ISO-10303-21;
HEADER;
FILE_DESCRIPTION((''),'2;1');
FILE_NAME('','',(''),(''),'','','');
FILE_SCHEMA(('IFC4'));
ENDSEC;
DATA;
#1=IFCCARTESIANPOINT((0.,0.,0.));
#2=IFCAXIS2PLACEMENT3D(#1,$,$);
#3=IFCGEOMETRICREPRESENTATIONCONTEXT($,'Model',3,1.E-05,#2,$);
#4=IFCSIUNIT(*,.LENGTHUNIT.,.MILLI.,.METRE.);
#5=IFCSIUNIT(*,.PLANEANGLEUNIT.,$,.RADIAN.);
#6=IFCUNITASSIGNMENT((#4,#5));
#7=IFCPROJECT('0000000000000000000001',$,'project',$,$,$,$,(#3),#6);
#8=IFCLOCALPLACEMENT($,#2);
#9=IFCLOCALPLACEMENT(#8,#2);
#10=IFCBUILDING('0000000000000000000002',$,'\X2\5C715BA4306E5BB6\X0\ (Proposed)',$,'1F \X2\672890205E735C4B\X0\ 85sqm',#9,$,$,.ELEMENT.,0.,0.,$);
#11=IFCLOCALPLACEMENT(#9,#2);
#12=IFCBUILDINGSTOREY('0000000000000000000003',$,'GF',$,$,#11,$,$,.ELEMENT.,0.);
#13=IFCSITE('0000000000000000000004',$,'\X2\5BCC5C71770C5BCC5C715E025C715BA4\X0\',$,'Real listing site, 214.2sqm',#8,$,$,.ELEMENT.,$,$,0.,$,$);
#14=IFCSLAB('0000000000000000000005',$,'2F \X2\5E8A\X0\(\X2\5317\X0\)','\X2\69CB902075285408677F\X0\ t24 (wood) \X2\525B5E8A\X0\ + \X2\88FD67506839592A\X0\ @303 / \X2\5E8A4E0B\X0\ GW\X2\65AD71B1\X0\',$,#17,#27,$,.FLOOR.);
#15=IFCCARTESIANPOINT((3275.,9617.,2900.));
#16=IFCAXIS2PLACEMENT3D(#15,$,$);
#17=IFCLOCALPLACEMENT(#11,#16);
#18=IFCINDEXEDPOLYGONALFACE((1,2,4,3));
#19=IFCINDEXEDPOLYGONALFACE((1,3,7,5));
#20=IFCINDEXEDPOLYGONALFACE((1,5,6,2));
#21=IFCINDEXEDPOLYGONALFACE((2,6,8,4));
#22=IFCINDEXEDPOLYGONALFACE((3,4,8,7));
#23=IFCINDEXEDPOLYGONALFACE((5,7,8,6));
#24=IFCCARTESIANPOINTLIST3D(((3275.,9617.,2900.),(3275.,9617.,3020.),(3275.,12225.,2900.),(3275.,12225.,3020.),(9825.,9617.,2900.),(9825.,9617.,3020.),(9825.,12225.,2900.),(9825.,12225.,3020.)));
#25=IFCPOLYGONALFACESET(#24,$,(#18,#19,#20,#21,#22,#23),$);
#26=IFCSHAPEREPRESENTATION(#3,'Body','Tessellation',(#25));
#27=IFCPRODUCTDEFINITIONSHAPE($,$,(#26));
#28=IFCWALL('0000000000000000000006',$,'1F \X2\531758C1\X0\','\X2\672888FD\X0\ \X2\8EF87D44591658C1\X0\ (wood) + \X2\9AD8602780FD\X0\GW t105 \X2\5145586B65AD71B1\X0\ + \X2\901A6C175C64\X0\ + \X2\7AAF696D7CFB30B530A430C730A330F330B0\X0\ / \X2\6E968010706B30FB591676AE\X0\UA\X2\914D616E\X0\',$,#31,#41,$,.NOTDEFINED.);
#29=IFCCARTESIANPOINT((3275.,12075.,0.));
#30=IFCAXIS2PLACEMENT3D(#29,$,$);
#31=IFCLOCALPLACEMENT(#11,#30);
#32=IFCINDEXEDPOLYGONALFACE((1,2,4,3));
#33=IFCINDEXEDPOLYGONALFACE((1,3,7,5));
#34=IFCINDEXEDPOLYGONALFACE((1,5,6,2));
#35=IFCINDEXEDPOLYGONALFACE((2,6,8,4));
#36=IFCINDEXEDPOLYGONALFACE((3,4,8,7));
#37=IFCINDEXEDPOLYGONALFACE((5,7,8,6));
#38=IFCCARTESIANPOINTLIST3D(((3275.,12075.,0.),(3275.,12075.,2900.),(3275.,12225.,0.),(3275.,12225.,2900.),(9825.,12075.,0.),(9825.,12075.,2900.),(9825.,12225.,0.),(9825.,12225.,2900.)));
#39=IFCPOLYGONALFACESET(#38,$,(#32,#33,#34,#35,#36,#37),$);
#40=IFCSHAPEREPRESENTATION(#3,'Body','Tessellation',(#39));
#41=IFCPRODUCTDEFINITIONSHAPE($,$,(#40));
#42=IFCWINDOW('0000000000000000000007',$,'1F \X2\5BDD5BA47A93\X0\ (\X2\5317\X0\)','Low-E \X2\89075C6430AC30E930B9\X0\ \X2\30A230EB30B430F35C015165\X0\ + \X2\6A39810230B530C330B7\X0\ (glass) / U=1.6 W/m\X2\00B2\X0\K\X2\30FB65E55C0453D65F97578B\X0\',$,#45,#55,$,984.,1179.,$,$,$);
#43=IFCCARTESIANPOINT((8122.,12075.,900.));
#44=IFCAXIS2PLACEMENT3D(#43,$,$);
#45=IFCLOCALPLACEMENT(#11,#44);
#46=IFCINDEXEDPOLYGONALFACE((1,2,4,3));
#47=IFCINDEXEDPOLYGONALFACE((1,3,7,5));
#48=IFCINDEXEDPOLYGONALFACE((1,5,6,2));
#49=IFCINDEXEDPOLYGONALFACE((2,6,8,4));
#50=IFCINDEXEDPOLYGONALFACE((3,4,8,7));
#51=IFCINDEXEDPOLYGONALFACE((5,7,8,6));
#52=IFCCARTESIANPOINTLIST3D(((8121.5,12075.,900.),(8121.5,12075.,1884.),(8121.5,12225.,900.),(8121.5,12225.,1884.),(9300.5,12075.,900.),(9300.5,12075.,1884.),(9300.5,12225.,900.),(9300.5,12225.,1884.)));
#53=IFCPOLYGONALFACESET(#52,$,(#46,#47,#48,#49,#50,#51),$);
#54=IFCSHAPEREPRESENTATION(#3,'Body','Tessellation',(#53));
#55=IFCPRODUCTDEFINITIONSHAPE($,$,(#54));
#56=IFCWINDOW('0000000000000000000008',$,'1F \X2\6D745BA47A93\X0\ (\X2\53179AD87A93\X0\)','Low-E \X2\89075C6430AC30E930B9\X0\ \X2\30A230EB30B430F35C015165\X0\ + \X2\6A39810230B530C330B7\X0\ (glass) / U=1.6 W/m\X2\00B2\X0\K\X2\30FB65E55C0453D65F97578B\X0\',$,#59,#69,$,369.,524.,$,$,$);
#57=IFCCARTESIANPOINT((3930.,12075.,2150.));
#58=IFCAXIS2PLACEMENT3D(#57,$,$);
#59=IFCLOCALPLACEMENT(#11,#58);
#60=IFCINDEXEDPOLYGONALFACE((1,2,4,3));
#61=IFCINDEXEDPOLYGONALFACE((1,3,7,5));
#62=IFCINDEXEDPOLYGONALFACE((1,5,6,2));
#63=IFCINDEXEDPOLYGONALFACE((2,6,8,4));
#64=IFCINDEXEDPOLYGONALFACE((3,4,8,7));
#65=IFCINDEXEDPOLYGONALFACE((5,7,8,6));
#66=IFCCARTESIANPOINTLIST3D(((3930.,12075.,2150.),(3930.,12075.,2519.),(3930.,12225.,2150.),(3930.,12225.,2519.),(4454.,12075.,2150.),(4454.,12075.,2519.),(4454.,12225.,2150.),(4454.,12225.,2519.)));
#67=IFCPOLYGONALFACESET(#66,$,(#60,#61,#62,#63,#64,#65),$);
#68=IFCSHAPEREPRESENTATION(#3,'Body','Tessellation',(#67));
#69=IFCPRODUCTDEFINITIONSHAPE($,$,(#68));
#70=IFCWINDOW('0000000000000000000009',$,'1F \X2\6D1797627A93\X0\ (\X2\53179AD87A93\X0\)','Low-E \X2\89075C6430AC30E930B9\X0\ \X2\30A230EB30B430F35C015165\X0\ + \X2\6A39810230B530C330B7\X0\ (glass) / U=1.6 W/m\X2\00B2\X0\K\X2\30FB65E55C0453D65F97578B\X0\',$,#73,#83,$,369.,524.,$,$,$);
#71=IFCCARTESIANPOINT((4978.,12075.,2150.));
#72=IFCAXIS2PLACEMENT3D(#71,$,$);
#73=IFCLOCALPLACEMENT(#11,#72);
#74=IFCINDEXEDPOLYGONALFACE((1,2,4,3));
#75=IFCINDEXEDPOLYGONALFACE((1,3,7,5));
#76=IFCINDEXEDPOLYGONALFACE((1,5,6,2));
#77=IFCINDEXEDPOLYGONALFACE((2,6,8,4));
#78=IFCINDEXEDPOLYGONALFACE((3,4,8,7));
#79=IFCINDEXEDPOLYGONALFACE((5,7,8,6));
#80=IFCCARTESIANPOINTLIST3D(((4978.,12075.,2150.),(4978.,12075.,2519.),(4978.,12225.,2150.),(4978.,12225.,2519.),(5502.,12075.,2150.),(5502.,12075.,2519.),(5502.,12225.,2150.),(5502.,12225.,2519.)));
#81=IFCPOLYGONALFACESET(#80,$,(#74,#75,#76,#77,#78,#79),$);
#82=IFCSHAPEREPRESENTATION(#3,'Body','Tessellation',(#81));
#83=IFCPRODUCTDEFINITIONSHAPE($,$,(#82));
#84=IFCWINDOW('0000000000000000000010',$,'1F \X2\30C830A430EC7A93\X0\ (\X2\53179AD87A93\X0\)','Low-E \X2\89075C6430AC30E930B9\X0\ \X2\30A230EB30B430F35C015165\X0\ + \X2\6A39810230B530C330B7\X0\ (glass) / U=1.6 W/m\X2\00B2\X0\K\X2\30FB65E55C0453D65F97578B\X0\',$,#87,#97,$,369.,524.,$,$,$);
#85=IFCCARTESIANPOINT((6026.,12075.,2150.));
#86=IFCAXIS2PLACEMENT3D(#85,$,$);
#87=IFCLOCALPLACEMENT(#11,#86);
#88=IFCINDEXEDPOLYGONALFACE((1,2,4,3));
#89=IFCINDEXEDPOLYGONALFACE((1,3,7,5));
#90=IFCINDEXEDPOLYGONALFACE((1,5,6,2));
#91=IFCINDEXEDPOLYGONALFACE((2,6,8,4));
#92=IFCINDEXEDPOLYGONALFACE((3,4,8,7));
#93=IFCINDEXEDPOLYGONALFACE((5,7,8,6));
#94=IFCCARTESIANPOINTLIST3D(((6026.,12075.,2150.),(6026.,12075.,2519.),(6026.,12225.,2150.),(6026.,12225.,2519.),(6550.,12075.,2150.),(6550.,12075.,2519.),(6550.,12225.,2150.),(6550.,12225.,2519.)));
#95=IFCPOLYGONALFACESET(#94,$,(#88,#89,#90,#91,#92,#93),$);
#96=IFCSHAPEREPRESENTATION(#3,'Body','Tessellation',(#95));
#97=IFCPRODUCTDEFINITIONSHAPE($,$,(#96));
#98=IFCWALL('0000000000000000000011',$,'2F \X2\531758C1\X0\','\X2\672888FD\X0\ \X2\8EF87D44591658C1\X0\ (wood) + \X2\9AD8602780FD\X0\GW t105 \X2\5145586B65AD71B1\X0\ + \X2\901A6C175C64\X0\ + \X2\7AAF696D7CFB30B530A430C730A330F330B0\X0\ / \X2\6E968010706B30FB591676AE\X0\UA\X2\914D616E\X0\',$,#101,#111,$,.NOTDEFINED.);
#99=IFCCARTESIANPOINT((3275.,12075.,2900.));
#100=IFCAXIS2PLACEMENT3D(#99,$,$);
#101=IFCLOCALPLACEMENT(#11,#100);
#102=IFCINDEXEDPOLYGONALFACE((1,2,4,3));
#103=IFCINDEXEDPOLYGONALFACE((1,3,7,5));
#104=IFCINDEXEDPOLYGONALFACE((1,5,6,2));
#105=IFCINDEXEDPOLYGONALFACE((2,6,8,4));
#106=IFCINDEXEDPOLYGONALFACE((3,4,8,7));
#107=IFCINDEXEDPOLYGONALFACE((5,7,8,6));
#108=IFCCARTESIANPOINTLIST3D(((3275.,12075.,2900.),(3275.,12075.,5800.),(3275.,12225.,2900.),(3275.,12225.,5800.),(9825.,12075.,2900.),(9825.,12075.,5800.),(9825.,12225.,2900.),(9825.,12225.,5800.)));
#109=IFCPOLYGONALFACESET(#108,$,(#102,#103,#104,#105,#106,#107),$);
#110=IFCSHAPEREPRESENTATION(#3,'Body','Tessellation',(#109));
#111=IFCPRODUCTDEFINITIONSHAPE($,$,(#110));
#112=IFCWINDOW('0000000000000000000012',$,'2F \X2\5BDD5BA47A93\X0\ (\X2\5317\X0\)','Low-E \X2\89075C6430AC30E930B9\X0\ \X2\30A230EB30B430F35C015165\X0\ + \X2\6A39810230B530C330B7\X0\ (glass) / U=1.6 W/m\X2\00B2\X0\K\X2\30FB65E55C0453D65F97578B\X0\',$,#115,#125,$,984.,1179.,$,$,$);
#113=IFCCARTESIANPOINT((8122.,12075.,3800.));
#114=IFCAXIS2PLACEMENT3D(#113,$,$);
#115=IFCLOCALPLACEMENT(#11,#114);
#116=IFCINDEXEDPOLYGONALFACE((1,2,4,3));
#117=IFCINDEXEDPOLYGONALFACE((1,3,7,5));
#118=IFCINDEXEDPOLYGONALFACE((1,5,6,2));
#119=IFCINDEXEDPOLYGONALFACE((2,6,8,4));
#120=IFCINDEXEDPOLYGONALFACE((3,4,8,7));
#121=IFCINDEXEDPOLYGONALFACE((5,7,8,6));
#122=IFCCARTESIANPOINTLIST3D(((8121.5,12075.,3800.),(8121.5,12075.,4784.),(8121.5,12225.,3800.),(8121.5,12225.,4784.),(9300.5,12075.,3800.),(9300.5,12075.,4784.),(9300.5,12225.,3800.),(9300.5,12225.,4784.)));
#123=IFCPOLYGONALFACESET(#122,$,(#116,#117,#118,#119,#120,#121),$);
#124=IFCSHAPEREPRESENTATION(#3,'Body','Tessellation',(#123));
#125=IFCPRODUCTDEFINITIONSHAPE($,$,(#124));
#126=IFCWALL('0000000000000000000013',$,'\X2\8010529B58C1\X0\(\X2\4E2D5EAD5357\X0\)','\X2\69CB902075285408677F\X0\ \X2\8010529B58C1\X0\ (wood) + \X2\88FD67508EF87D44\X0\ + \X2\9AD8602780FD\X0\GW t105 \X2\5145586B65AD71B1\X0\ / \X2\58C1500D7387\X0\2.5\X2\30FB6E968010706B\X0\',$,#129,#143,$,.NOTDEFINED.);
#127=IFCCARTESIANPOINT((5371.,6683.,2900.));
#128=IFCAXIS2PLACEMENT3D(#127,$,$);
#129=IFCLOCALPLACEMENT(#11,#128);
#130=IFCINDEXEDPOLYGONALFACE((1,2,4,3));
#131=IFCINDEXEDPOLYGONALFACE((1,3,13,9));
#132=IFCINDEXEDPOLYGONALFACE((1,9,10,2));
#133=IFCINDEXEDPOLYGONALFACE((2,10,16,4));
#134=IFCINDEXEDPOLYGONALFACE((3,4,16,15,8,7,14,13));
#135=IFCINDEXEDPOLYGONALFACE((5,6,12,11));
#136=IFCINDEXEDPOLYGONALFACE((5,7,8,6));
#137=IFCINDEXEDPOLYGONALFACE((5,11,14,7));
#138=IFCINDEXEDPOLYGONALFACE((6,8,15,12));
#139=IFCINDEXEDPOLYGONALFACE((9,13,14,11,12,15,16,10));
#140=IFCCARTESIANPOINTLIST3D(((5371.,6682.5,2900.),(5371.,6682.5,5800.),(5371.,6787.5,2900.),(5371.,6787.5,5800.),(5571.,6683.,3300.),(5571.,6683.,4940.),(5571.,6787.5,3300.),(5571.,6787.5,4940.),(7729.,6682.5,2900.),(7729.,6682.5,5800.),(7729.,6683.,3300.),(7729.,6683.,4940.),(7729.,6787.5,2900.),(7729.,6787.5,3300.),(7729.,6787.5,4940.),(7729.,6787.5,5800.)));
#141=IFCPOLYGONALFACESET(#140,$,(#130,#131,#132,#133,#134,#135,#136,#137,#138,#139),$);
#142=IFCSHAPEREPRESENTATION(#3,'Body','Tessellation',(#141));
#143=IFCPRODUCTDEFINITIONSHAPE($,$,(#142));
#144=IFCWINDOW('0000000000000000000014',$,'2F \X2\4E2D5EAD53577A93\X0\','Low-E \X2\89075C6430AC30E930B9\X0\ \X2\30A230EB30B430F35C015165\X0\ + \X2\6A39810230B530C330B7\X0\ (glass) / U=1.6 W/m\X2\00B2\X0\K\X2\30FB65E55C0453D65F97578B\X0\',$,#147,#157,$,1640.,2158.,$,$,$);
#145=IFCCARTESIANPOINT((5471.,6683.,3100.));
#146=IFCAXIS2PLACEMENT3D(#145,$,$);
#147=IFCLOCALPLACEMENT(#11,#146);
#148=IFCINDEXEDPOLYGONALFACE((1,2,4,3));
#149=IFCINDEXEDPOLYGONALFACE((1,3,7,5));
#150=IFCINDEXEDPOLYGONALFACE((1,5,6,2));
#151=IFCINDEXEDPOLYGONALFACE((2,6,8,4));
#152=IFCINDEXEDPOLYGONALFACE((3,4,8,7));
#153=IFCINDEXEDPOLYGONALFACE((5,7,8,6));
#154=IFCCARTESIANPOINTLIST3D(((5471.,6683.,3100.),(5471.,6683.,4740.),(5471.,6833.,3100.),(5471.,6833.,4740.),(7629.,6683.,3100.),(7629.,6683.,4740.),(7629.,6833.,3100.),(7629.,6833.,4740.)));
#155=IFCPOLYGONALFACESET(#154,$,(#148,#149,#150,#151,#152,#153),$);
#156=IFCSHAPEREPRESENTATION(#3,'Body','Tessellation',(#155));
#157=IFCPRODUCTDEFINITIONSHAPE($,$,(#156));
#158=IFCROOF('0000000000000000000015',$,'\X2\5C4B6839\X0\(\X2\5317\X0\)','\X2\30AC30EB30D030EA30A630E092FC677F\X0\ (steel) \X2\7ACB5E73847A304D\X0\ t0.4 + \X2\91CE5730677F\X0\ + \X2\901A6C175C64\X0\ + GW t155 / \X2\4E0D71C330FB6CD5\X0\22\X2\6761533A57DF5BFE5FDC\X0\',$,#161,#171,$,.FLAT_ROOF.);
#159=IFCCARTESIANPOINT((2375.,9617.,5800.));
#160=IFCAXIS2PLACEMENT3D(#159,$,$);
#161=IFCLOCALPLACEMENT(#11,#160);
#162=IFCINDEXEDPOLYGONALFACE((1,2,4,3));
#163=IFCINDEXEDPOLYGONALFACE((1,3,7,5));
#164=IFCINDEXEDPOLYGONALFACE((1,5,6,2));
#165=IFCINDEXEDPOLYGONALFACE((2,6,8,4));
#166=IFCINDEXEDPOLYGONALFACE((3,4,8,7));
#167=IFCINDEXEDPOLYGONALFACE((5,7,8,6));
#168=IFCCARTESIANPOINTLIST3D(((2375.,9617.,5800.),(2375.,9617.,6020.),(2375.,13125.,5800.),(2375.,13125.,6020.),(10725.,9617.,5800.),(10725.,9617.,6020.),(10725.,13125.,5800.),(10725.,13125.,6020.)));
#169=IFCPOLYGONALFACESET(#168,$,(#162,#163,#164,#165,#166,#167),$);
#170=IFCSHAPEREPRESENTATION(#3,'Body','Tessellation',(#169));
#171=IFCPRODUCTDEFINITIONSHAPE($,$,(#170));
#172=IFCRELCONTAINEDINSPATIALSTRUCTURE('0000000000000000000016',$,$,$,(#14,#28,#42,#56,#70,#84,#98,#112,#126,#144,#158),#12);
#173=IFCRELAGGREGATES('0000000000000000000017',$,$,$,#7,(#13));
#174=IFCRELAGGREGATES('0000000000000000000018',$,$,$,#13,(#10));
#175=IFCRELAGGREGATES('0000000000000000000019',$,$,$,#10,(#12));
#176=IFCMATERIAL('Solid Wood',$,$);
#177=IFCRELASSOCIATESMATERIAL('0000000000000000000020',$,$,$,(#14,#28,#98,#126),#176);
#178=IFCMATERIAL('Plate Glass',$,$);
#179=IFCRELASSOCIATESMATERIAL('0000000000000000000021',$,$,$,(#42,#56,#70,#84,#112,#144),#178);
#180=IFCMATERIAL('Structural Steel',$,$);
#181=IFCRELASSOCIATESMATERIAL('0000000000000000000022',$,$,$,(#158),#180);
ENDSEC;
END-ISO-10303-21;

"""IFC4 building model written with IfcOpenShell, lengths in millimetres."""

from ifc_helpers import new_model, si_unit, frame, frame_2d, origin, place, context, project, spatial, rectangle, extrude, material, element, fill, save


model = new_model("IFC4")

# Units and contexts
model_context = context("Model", 3, precision=1e-05, world=origin())
ifc_project = project(units=[si_unit("LENGTHUNIT", "METRE", prefix="MILLI"), si_unit("PLANEANGLEUNIT", "RADIAN")], contexts=[model_context])

# Site, building, storey
site_placement = place(None, origin())
site = spatial("IfcSite", under=ifc_project, at=site_placement, Name="富山県富山市山室", ObjectType="Real listing site, 214.2sqm", CompositionType="ELEMENT", RefElevation=0.0)
building_placement = place(site_placement, origin())
building = spatial("IfcBuilding", under=site, at=building_placement, Name="山室の家 (Proposed)", ObjectType="1F 木造平屋 85sqm", CompositionType="ELEMENT", ElevationOfRefHeight=0.0, ElevationOfTerrain=0.0)
storey_placement = place(building_placement, origin())
storey = spatial("IfcBuildingStorey", under=building, at=storey_placement, Name="GF", CompositionType="ELEMENT", Elevation=0.0)

# Slab
ifc_material_1 = material(Name="Solid Wood")
slab_1_placement = place(storey_placement, frame((3275.0, 9617.0, 2900.0)))
element("IfcSlab", 1, at=slab_1_placement, inside=storey, material=ifc_material_1, Name="2F 床(北)", Description="構造用合板 t24 (wood) 剛床 + 製材根太 @303 / 床下 GW断熱", PredefinedType="FLOOR", context=model_context, shape_type="SweptSolid", body=[
    extrude(rectangle(XDim=6550.0, YDim=2608.0, at=frame_2d((3275.0, 1304.0))), frame((3275.0, 9617.0, 2900.0)), (0.0, 0.0, 1.0), 120.0),
])

# Wall, openings, windows
wall_1_placement = place(storey_placement, frame((3275.0, 12075.0, 0.0)))
wall_1 = element("IfcWall", 2, at=wall_1_placement, inside=storey, material=ifc_material_1, Name="1F 北壁", Description="木製 軸組外壁 (wood) + 高性能GW t105 充填断熱 + 通気層 + 窯業系サイディング / 準耐火・外皮UA配慮", PredefinedType="NOTDEFINED", context=model_context, shape_type="SweptSolid", body=[
    extrude(rectangle(XDim=6550.0, YDim=150.0, at=frame_2d((3275.0, 75.0))), frame((3275.0, 12075.0, 0.0)), (0.0, 0.0, 1.0), 2900.0),
])
opening_1_placement = place(storey_placement, frame((8122.0, 12075.0, 900.0)))
opening_1 = element("IfcOpeningElement", 3, at=opening_1_placement, cuts=wall_1, PredefinedType="NOTDEFINED", context=model_context, shape_type="SweptSolid", body=[
    extrude(rectangle(XDim=1179.0, YDim=150.0, at=frame_2d((589.0, 75.0))), frame((8122.0, 12075.0, 900.0)), (0.0, 0.0, 1.0), 984.0),
])
opening_2_placement = place(storey_placement, frame((3930.0, 12075.0, 2150.0)))
opening_2 = element("IfcOpeningElement", 4, at=opening_2_placement, cuts=wall_1, PredefinedType="NOTDEFINED", context=model_context, shape_type="SweptSolid", body=[
    extrude(rectangle(XDim=524.0, YDim=150.0, at=frame_2d((262.0, 75.0))), frame((3930.0, 12075.0, 2150.0)), (0.0, 0.0, 1.0), 369.0),
])
opening_3_placement = place(storey_placement, frame((4978.0, 12075.0, 2150.0)))
opening_3 = element("IfcOpeningElement", 5, at=opening_3_placement, cuts=wall_1, PredefinedType="NOTDEFINED", context=model_context, shape_type="SweptSolid", body=[
    extrude(rectangle(XDim=524.0, YDim=150.0, at=frame_2d((262.0, 75.0))), frame((4978.0, 12075.0, 2150.0)), (0.0, 0.0, 1.0), 369.0),
])
opening_4_placement = place(storey_placement, frame((6026.0, 12075.0, 2150.0)))
opening_4 = element("IfcOpeningElement", 6, at=opening_4_placement, cuts=wall_1, PredefinedType="NOTDEFINED", context=model_context, shape_type="SweptSolid", body=[
    extrude(rectangle(XDim=524.0, YDim=150.0, at=frame_2d((262.0, 75.0))), frame((6026.0, 12075.0, 2150.0)), (0.0, 0.0, 1.0), 369.0),
])
ifc_material_2 = material(Name="Plate Glass")
window_1_placement = place(storey_placement, frame((8122.0, 12075.0, 900.0)))
window_1 = element("IfcWindow", 7, at=window_1_placement, inside=storey, material=ifc_material_2, Name="1F 寝室窓 (北)", Description="Low-E 複層ガラス アルゴン封入 + 樹脂サッシ (glass) / U=1.6 W/m²K・日射取得型", OverallHeight=984.0, OverallWidth=1179.0, context=model_context, shape_type="SweptSolid", body=[
    extrude(rectangle(XDim=1179.0, YDim=150.0, at=frame_2d((589.0, 75.0))), frame((8122.0, 12075.0, 900.0)), (0.0, 0.0, 1.0), 984.0),
])
fill(opening_1, window_1)
window_2_placement = place(storey_placement, frame((3930.0, 12075.0, 2150.0)))
window_2 = element("IfcWindow", 8, at=window_2_placement, inside=storey, material=ifc_material_2, Name="1F 浴室窓 (北高窓)", Description="Low-E 複層ガラス アルゴン封入 + 樹脂サッシ (glass) / U=1.6 W/m²K・日射取得型", OverallHeight=369.0, OverallWidth=524.0, context=model_context, shape_type="SweptSolid", body=[
    extrude(rectangle(XDim=524.0, YDim=150.0, at=frame_2d((262.0, 75.0))), frame((3930.0, 12075.0, 2150.0)), (0.0, 0.0, 1.0), 369.0),
])
fill(opening_2, window_2)
window_3_placement = place(storey_placement, frame((4978.0, 12075.0, 2150.0)))
window_3 = element("IfcWindow", 9, at=window_3_placement, inside=storey, material=ifc_material_2, Name="1F 洗面窓 (北高窓)", Description="Low-E 複層ガラス アルゴン封入 + 樹脂サッシ (glass) / U=1.6 W/m²K・日射取得型", OverallHeight=369.0, OverallWidth=524.0, context=model_context, shape_type="SweptSolid", body=[
    extrude(rectangle(XDim=524.0, YDim=150.0, at=frame_2d((262.0, 75.0))), frame((4978.0, 12075.0, 2150.0)), (0.0, 0.0, 1.0), 369.0),
])
fill(opening_3, window_3)
window_4_placement = place(storey_placement, frame((6026.0, 12075.0, 2150.0)))
window_4 = element("IfcWindow", 10, at=window_4_placement, inside=storey, material=ifc_material_2, Name="1F トイレ窓 (北高窓)", Description="Low-E 複層ガラス アルゴン封入 + 樹脂サッシ (glass) / U=1.6 W/m²K・日射取得型", OverallHeight=369.0, OverallWidth=524.0, context=model_context, shape_type="SweptSolid", body=[
    extrude(rectangle(XDim=524.0, YDim=150.0, at=frame_2d((262.0, 75.0))), frame((6026.0, 12075.0, 2150.0)), (0.0, 0.0, 1.0), 369.0),
])
fill(opening_4, window_4)

# Walls, openings, windows
wall_2_placement = place(storey_placement, frame((3275.0, 12075.0, 2900.0)))
wall_2 = element("IfcWall", 11, at=wall_2_placement, inside=storey, material=ifc_material_1, Name="2F 北壁", Description="木製 軸組外壁 (wood) + 高性能GW t105 充填断熱 + 通気層 + 窯業系サイディング / 準耐火・外皮UA配慮", PredefinedType="NOTDEFINED", context=model_context, shape_type="SweptSolid", body=[
    extrude(rectangle(XDim=6550.0, YDim=150.0, at=frame_2d((3275.0, 75.0))), frame((3275.0, 12075.0, 2900.0)), (0.0, 0.0, 1.0), 2900.0),
])
opening_5_placement = place(storey_placement, frame((8122.0, 12075.0, 3800.0)))
opening_5 = element("IfcOpeningElement", 12, at=opening_5_placement, cuts=wall_2, PredefinedType="NOTDEFINED", context=model_context, shape_type="SweptSolid", body=[
    extrude(rectangle(XDim=1179.0, YDim=150.0, at=frame_2d((589.0, 75.0))), frame((8122.0, 12075.0, 3800.0)), (0.0, 0.0, 1.0), 984.0),
])
window_5_placement = place(storey_placement, frame((8122.0, 12075.0, 3800.0)))
window_5 = element("IfcWindow", 13, at=window_5_placement, inside=storey, material=ifc_material_2, Name="2F 寝室窓 (北)", Description="Low-E 複層ガラス アルゴン封入 + 樹脂サッシ (glass) / U=1.6 W/m²K・日射取得型", OverallHeight=984.0, OverallWidth=1179.0, context=model_context, shape_type="SweptSolid", body=[
    extrude(rectangle(XDim=1179.0, YDim=150.0, at=frame_2d((589.0, 75.0))), frame((8122.0, 12075.0, 3800.0)), (0.0, 0.0, 1.0), 984.0),
])
fill(opening_5, window_5)
wall_3_placement = place(storey_placement, frame((5371.0, 6683.0, 2900.0)))
wall_3 = element("IfcWall", 14, at=wall_3_placement, inside=storey, material=ifc_material_1, Name="耐力壁(中庭南)", Description="構造用合板 耐力壁 (wood) + 製材軸組 + 高性能GW t105 充填断熱 / 壁倍率2.5・準耐火", PredefinedType="NOTDEFINED", context=model_context, shape_type="SweptSolid", body=[
    extrude(rectangle(XDim=2358.0, YDim=105.0, at=frame_2d((1179.0, 52.0))), frame((5371.0, 6683.0, 2900.0)), (0.0, 0.0, 1.0), 2900.0),
])
opening_6_placement = place(storey_placement, frame((5471.0, 6683.0, 3100.0)))
opening_6 = element("IfcOpeningElement", 15, at=opening_6_placement, cuts=wall_3, PredefinedType="NOTDEFINED", context=model_context, shape_type="SweptSolid", body=[
    extrude(rectangle(XDim=2158.0, YDim=150.0, at=frame_2d((1079.0, 75.0))), frame((5471.0, 6683.0, 3100.0)), (0.0, 0.0, 1.0), 1640.0),
])
window_6_placement = place(storey_placement, frame((5471.0, 6683.0, 3100.0)))
window_6 = element("IfcWindow", 16, at=window_6_placement, inside=storey, material=ifc_material_2, Name="2F 中庭南窓", Description="Low-E 複層ガラス アルゴン封入 + 樹脂サッシ (glass) / U=1.6 W/m²K・日射取得型", OverallHeight=1640.0, OverallWidth=2158.0, context=model_context, shape_type="SweptSolid", body=[
    extrude(rectangle(XDim=2158.0, YDim=150.0, at=frame_2d((1079.0, 75.0))), frame((5471.0, 6683.0, 3100.0)), (0.0, 0.0, 1.0), 1640.0),
])
fill(opening_6, window_6)

# Roof
ifc_material_3 = material(Name="Structural Steel")
for number, where, name in (
    (17, (2375.0, 9617.0, 5800.0), "屋根(北)"),
):
    element("IfcRoof", number, at=place(storey_placement, frame(where)), inside=storey, material=ifc_material_3, Name=name, Description="ガルバリウム鋼板 (steel) 立平葺き t0.4 + 野地板 + 通気層 + GW t155 / 不燃・法22条区域対応", PredefinedType="FLAT_ROOF", context=model_context, shape_type="SweptSolid", body=[
        extrude(rectangle(XDim=8350.0, YDim=3508.0, at=frame_2d((4175.0, 1754.0))), frame((2375.0, 9617.0, 5800.0)), (0.0, 0.0, 1.0), 220.0),
    ])

save(model, "model.ifc")
